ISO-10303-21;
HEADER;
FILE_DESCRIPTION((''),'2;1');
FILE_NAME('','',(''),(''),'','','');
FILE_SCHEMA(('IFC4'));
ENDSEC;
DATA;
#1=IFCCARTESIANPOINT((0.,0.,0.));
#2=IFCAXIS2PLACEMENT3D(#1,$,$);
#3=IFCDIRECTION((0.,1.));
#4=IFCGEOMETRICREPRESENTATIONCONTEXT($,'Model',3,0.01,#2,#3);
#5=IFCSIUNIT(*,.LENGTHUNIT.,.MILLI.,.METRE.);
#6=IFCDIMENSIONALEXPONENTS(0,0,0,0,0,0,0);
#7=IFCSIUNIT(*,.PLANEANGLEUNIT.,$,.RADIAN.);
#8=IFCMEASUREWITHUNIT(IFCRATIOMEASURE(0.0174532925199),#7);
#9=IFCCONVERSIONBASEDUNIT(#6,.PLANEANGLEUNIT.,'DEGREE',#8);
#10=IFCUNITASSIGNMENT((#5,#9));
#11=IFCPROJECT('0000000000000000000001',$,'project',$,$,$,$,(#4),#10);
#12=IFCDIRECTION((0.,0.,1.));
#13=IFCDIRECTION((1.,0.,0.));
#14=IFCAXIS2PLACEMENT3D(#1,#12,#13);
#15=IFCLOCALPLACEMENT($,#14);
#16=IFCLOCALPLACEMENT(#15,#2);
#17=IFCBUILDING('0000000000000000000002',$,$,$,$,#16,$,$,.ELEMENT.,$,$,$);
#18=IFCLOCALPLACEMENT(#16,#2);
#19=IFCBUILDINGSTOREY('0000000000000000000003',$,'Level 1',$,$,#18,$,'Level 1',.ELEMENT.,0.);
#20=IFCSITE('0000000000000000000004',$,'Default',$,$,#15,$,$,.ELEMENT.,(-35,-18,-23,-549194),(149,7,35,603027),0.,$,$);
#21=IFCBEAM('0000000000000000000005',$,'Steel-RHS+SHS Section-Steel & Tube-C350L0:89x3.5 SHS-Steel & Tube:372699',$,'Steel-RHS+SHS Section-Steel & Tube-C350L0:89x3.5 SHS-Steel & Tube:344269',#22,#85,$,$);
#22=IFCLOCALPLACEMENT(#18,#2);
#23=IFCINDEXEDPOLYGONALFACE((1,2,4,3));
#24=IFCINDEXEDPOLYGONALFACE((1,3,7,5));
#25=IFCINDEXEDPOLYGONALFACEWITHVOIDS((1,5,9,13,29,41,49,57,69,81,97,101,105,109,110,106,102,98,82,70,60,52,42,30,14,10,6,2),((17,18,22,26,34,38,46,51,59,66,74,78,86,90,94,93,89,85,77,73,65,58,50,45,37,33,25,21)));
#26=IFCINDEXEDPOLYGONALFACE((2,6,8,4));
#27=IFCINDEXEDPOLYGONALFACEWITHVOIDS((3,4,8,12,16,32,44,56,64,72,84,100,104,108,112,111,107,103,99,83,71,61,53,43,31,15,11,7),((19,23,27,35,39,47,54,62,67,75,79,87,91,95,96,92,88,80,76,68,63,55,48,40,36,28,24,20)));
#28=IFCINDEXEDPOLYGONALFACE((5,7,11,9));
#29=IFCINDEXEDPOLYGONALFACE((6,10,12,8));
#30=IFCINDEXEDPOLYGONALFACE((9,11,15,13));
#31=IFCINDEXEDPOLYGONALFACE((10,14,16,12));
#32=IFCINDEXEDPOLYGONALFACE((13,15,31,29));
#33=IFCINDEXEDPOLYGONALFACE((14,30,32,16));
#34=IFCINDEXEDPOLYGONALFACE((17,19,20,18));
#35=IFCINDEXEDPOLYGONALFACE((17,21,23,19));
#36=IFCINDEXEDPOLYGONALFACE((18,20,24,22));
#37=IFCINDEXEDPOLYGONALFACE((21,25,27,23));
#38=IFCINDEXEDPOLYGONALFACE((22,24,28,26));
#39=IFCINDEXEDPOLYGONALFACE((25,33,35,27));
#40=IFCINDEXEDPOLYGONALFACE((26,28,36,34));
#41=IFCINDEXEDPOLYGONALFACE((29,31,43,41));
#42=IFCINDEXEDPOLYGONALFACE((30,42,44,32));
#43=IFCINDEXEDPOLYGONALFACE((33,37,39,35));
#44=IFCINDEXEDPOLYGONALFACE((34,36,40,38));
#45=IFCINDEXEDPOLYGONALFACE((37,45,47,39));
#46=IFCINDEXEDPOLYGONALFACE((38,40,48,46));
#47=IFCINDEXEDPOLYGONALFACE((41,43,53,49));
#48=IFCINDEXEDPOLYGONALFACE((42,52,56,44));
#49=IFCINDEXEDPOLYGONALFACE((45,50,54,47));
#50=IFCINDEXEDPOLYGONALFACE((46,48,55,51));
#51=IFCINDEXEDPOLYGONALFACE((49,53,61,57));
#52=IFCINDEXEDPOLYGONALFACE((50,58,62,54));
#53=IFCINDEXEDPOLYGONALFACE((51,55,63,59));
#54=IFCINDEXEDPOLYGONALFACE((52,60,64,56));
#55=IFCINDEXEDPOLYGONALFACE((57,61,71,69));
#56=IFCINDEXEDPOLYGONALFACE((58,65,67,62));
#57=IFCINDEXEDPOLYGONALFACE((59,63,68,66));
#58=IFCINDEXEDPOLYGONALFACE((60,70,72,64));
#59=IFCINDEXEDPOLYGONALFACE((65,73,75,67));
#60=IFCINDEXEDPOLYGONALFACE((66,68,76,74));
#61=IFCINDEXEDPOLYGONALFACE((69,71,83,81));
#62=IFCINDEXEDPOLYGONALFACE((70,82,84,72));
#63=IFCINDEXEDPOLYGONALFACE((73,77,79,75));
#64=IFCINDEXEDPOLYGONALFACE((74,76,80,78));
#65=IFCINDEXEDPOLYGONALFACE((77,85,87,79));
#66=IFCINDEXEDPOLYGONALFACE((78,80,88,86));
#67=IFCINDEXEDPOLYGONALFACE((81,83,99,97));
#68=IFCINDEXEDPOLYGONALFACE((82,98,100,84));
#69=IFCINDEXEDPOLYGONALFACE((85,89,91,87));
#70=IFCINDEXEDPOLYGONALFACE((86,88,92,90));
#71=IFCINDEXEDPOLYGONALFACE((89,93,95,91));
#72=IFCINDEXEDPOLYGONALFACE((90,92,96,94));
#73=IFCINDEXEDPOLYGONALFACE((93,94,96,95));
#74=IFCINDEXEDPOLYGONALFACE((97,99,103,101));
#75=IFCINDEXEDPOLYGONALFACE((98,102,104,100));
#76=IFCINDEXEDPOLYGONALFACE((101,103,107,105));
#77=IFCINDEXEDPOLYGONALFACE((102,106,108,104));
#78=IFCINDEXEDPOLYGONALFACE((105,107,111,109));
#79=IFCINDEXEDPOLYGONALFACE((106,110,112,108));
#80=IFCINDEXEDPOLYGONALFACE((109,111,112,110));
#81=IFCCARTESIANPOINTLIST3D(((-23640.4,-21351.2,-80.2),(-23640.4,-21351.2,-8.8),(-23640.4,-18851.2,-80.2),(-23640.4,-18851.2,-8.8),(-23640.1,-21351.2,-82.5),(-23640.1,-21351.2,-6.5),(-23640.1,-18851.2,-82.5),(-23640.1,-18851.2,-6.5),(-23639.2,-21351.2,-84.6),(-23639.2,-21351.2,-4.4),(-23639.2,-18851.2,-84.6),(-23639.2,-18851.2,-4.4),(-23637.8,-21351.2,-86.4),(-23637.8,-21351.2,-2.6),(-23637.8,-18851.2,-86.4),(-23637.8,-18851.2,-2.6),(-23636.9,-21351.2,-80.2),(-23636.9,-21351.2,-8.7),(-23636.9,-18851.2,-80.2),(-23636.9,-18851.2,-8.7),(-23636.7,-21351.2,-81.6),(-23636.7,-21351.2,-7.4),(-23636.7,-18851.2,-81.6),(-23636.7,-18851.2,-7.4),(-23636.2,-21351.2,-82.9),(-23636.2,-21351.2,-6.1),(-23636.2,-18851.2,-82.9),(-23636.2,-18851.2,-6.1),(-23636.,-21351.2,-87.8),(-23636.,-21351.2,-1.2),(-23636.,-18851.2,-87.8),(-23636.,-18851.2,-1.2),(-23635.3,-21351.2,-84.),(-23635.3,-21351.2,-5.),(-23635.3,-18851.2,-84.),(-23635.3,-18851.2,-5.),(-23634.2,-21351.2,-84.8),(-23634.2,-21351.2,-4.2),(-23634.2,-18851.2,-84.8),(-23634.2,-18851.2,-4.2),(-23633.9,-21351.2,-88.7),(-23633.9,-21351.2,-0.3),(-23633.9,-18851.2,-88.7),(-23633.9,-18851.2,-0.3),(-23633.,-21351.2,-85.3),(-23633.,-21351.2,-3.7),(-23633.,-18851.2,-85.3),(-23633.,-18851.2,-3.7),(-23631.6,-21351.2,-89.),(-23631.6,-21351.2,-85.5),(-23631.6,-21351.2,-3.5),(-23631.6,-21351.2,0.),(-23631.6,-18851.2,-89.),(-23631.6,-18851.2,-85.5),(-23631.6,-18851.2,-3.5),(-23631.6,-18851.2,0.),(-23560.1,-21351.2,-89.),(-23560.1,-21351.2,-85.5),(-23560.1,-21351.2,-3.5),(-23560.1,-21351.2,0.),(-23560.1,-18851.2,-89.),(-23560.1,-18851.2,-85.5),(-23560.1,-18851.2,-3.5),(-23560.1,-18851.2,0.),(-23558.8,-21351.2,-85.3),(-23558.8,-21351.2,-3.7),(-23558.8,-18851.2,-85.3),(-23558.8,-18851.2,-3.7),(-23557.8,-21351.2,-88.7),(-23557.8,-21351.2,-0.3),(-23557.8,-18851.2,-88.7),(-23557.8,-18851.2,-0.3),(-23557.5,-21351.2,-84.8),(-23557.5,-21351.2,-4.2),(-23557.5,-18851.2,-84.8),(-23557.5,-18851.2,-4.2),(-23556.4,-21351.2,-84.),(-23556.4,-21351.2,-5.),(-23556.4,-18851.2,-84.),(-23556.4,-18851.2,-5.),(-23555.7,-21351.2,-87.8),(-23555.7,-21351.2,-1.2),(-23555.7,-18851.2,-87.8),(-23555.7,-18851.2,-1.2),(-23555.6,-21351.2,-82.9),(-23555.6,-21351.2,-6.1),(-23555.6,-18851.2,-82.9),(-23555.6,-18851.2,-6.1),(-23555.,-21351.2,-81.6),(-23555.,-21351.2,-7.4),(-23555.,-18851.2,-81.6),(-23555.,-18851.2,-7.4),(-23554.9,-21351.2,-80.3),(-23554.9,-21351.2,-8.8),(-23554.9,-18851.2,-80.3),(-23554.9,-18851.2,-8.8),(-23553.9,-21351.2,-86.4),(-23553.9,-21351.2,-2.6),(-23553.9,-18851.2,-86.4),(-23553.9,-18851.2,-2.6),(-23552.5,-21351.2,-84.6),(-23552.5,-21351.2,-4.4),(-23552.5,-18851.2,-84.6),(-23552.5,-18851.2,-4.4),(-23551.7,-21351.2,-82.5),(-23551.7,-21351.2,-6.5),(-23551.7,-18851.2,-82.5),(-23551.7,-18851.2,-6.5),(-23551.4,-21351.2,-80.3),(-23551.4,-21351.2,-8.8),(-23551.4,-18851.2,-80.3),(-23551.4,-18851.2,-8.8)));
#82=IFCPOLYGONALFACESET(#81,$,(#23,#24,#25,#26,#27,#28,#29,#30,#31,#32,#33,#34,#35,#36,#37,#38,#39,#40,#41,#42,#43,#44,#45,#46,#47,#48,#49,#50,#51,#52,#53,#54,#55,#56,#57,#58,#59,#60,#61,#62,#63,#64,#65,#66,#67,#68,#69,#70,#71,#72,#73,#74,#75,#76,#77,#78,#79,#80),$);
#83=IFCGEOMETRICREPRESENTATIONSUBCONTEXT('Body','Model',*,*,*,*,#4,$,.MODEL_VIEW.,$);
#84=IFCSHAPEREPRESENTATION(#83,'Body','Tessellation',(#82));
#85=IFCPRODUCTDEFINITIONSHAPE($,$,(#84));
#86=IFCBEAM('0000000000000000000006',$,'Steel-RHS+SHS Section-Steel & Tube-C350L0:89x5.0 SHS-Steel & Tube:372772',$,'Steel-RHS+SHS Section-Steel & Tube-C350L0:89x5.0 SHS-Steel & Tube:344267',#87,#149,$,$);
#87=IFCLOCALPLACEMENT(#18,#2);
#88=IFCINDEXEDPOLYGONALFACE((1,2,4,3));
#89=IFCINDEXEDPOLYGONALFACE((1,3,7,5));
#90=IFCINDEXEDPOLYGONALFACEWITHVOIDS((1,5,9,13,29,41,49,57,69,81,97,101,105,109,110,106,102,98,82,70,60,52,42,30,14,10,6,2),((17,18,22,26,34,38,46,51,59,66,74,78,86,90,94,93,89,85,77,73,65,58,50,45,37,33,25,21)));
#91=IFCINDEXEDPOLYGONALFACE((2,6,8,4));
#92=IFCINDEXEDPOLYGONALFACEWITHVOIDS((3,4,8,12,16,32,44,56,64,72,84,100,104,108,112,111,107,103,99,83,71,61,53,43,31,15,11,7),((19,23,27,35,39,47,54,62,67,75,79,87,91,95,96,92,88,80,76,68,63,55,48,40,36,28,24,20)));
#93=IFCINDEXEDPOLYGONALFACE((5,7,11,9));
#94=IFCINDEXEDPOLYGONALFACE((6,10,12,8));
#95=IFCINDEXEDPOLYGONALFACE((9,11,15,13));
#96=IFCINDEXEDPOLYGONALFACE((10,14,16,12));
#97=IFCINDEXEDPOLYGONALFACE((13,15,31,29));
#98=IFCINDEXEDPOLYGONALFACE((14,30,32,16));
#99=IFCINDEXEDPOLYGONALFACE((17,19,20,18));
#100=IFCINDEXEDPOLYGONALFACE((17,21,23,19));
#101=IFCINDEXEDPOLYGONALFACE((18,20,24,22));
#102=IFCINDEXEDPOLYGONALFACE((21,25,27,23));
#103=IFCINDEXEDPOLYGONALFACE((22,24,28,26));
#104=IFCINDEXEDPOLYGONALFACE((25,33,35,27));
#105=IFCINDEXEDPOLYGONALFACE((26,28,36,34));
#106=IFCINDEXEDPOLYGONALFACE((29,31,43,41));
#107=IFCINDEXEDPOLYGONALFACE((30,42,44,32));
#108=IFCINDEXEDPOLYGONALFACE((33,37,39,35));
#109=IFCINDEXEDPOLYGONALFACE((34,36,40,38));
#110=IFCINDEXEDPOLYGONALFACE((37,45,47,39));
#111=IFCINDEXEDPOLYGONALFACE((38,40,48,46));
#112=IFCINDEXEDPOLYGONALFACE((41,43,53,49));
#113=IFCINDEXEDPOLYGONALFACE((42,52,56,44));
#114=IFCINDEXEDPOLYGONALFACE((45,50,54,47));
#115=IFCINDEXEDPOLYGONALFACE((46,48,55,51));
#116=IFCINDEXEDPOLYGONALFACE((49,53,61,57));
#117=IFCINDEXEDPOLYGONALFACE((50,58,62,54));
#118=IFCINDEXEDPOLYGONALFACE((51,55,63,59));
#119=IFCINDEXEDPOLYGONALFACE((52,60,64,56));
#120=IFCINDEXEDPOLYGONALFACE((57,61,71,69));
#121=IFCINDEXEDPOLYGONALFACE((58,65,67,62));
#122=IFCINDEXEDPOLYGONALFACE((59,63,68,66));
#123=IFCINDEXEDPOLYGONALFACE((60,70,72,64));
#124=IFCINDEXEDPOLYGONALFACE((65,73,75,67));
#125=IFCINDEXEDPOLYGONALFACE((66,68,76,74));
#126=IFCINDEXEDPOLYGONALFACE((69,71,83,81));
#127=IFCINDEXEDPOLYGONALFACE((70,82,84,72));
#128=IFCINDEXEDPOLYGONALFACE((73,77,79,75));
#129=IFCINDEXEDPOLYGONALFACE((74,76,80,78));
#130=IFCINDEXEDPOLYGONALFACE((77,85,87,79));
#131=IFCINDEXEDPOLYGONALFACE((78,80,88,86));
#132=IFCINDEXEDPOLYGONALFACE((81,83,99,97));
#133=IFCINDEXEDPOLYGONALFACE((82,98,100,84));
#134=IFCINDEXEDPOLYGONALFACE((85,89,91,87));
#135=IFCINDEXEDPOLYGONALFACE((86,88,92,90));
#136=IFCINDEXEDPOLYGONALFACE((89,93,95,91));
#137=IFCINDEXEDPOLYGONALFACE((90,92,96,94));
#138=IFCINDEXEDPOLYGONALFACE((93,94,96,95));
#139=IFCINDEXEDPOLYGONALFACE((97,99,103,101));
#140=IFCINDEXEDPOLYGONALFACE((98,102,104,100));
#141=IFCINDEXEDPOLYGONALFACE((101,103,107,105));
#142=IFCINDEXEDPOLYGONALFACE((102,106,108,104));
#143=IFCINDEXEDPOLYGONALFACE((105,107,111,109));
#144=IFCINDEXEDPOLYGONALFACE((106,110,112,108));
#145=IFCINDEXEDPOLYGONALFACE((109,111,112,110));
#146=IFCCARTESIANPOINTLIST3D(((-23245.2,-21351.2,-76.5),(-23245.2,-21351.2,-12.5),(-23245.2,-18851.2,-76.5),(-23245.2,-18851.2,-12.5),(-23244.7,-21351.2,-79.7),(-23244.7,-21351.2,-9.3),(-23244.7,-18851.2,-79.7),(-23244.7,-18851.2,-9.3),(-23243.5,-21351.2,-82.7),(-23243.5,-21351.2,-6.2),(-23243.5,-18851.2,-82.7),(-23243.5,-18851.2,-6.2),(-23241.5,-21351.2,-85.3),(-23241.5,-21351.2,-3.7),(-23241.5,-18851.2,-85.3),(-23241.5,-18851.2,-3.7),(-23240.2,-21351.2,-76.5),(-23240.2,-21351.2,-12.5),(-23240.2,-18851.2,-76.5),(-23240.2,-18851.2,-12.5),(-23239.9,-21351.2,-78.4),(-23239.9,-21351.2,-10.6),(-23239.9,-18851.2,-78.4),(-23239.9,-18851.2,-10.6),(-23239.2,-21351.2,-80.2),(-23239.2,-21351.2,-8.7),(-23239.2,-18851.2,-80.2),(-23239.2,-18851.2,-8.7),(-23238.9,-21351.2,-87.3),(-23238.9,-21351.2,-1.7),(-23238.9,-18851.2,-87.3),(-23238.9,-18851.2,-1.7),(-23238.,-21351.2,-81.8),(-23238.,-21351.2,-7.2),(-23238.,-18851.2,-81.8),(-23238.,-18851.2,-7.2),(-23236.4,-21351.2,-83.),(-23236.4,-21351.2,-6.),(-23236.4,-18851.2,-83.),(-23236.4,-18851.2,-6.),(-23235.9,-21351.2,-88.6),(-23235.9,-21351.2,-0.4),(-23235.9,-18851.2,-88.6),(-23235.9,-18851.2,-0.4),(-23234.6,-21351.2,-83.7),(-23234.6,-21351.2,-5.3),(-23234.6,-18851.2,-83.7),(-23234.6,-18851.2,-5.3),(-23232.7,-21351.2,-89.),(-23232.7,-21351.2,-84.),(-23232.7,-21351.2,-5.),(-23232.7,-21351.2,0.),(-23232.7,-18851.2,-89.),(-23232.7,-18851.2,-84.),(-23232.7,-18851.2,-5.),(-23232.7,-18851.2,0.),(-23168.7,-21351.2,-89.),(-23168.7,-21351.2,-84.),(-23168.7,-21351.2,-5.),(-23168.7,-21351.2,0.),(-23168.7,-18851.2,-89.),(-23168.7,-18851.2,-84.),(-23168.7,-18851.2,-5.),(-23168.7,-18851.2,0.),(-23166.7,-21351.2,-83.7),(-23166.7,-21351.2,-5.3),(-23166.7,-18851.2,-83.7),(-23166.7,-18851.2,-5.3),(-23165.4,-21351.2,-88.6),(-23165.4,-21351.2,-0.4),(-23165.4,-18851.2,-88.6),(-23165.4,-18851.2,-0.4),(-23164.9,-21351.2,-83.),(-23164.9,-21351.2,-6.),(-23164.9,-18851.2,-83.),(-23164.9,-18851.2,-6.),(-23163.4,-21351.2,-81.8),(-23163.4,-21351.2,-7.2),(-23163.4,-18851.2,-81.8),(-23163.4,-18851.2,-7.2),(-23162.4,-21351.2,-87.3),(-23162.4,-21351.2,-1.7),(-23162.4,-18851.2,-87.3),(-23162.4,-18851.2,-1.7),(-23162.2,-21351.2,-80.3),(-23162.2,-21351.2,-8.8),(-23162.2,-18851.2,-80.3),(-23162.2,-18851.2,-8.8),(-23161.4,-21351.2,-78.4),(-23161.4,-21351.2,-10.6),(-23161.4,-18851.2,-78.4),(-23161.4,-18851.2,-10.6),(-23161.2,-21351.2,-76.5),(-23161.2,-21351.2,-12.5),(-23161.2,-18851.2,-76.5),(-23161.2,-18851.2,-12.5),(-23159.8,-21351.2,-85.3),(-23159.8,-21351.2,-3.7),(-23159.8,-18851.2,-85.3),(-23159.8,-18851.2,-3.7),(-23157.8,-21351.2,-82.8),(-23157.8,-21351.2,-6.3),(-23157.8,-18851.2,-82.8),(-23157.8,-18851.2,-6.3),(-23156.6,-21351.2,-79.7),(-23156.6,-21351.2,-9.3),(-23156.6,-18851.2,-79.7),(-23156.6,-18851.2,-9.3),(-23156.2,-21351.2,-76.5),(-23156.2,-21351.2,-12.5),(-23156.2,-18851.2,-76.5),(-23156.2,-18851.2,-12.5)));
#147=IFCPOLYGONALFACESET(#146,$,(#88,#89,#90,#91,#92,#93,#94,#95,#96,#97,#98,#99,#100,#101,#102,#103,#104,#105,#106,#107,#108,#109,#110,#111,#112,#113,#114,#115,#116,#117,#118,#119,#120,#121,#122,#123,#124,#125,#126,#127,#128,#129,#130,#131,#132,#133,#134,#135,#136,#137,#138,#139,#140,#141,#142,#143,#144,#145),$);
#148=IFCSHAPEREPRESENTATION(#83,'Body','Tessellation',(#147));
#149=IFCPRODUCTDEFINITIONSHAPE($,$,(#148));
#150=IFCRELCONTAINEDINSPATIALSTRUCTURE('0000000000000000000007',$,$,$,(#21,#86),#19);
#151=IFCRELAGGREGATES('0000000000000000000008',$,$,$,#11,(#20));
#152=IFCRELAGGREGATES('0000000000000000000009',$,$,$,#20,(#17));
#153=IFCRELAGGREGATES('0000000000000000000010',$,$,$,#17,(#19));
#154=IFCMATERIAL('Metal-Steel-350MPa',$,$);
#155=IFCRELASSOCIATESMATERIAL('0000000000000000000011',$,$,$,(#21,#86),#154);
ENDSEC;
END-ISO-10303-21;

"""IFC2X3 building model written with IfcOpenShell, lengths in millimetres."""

from ifc_helpers import new_model, entity, si_unit, converted_unit, direction, frame, frame_2d, origin, origin_with_axes, place, context, subcontext, project, spatial, polyline, circle_curve, parameter, trimmed, segment, composite_curve, outline, extrude, material, element, save


model = new_model("IFC2X3")

# Units and contexts
model_context = context("Model", 3, precision=0.01, world=origin(), true_north=direction((0.0, 1.0)))
body_context = subcontext(model_context, "Body", "Model", "MODEL_VIEW")
ifc_project = project(units=[si_unit("LENGTHUNIT", "METRE", prefix="MILLI"), converted_unit("PLANEANGLEUNIT", "DEGREE", entity("IfcRatioMeasure", 0.0174532925199), si_unit("PLANEANGLEUNIT", "RADIAN"), dimensions=[0, 0, 0, 0, 0, 0, 0])], contexts=[model_context])

# Site, building, storey
site_placement = place(None, origin_with_axes())
site = spatial("IfcSite", under=ifc_project, at=site_placement, Name="Default", CompositionType="ELEMENT", RefLatitude=(-35, -18, -23, -549194), RefLongitude=(149, 7, 35, 603027), RefElevation=0.0)
building_placement = place(site_placement, origin())
building = spatial("IfcBuilding", under=site, at=building_placement, CompositionType="ELEMENT")
storey_placement = place(building_placement, origin())
storey = spatial("IfcBuildingStorey", under=building, at=storey_placement, Name="Level 1", LongName="Level 1", CompositionType="ELEMENT", Elevation=0.0)

# Beams
ifc_material = material(Name="Metal-Steel-350MPa")
beam_1_placement = place(storey_placement, frame((-23595.9, -18851.2, 0.0), z_axis=(0.0, 0.0, 1.0), x_axis=(0.0, -1.0, 0.0)))
element("IfcBeam", 1, at=beam_1_placement, inside=storey, material=ifc_material, Name="Steel-RHS+SHS Section-Steel & Tube-C350L0:89x3.5 SHS-Steel & Tube:372699", ObjectType="Steel-RHS+SHS Section-Steel & Tube-C350L0:89x3.5 SHS-Steel & Tube:344269", context=body_context, shape_type="SweptSolid", body=[
    extrude(outline(composite_curve([segment(trimmed(circle_curve(frame_2d((-35.8, -35.8), x_axis=(1.0, 0.0)), 8.8), [parameter(180.0)], [parameter(270.0)], True, "PARAMETER"), True, "CONTINUOUS"), segment(polyline([(-35.8, -44.5), (35.8, -44.5)]), True, "CONTINUOUS"), segment(trimmed(circle_curve(frame_2d((35.8, -35.8), x_axis=(1.0, 0.0)), 8.8), [parameter(270.0)], [parameter(0.0)], True, "PARAMETER"), True, "CONTINUOUS"), segment(polyline([(44.5, -35.8), (44.5, 35.8)]), True, "CONTINUOUS"), segment(trimmed(circle_curve(frame_2d((35.8, 35.8), x_axis=(1.0, 0.0)), 8.8), [parameter(0.0)], [parameter(90.0)], True, "PARAMETER"), True, "CONTINUOUS"), segment(polyline([(35.8, 44.5), (-35.8, 44.5)]), True, "CONTINUOUS"), segment(trimmed(circle_curve(frame_2d((-35.8, 35.8), x_axis=(1.0, 0.0)), 8.8), [parameter(90.0)], [parameter(180.0)], True, "PARAMETER"), True, "CONTINUOUS"), segment(polyline([(-44.5, 35.8), (-44.5, -35.8)]), True, "CONTINUOUS")], self_intersect=False), holes=[composite_curve([segment(polyline([(35.8, -41.0), (-35.8, -41.0)]), True, "CONTINUOUS"), segment(trimmed(circle_curve(frame_2d((-35.8, -35.8), x_axis=(1.0, 0.0)), 5.2), [parameter(180.0)], [parameter(270.0)], True, "PARAMETER"), False, "CONTINUOUS"), segment(polyline([(-41.0, -35.8), (-41.0, 35.8)]), True, "CONTINUOUS"), segment(trimmed(circle_curve(frame_2d((-35.8, 35.8), x_axis=(1.0, 0.0)), 5.2), [parameter(90.0)], [parameter(180.0)], True, "PARAMETER"), False, "CONTINUOUS"), segment(polyline([(-35.8, 41.0), (35.8, 41.0)]), True, "CONTINUOUS"), segment(trimmed(circle_curve(frame_2d((35.8, 35.8), x_axis=(1.0, 0.0)), 5.2), [parameter(360.0)], [parameter(90.0)], True, "PARAMETER"), False, "CONTINUOUS"), segment(polyline([(41.0, 35.8), (41.0, -35.8)]), True, "CONTINUOUS"), segment(trimmed(circle_curve(frame_2d((35.8, -35.8), x_axis=(1.0, 0.0)), 5.2), [parameter(270.0)], [parameter(360.0)], True, "PARAMETER"), False, "CONTINUOUS")], self_intersect=False)]), frame((0.0, 0.0, -44.5), z_axis=(1.0, 0.0, 0.0), x_axis=(0.0, -1.0, 0.0)), (0.0, 0.0, 1.0), 2500.0),
])
beam_2_placement = place(storey_placement, frame((-23200.7, -18851.2, 0.0), z_axis=(0.0, 0.0, 1.0), x_axis=(0.0, -1.0, 0.0)))
element("IfcBeam", 2, at=beam_2_placement, inside=storey, material=ifc_material, Name="Steel-RHS+SHS Section-Steel & Tube-C350L0:89x5.0 SHS-Steel & Tube:372772", ObjectType="Steel-RHS+SHS Section-Steel & Tube-C350L0:89x5.0 SHS-Steel & Tube:344267", context=body_context, shape_type="SweptSolid", body=[
    extrude(outline(composite_curve([segment(trimmed(circle_curve(frame_2d((-32.0, -32.0), x_axis=(1.0, 0.0)), 12.5), [parameter(180.0)], [parameter(270.0)], True, "PARAMETER"), True, "CONTINUOUS"), segment(polyline([(-32.0, -44.5), (32.0, -44.5)]), True, "CONTINUOUS"), segment(trimmed(circle_curve(frame_2d((32.0, -32.0), x_axis=(1.0, 0.0)), 12.5), [parameter(270.0)], [parameter(0.0)], True, "PARAMETER"), True, "CONTINUOUS"), segment(polyline([(44.5, -32.0), (44.5, 32.0)]), True, "CONTINUOUS"), segment(trimmed(circle_curve(frame_2d((32.0, 32.0), x_axis=(1.0, 0.0)), 12.5), [parameter(0.0)], [parameter(90.0)], True, "PARAMETER"), True, "CONTINUOUS"), segment(polyline([(32.0, 44.5), (-32.0, 44.5)]), True, "CONTINUOUS"), segment(trimmed(circle_curve(frame_2d((-32.0, 32.0), x_axis=(1.0, 0.0)), 12.5), [parameter(90.0)], [parameter(180.0)], True, "PARAMETER"), True, "CONTINUOUS"), segment(polyline([(-44.5, 32.0), (-44.5, -32.0)]), True, "CONTINUOUS")], self_intersect=False), holes=[composite_curve([segment(polyline([(32.0, -39.5), (-32.0, -39.5)]), True, "CONTINUOUS"), segment(trimmed(circle_curve(frame_2d((-32.0, -32.0), x_axis=(1.0, 0.0)), 7.5), [parameter(180.0)], [parameter(270.0)], True, "PARAMETER"), False, "CONTINUOUS"), segment(polyline([(-39.5, -32.0), (-39.5, 32.0)]), True, "CONTINUOUS"), segment(trimmed(circle_curve(frame_2d((-32.0, 32.0), x_axis=(1.0, 0.0)), 7.5), [parameter(90.0)], [parameter(180.0)], True, "PARAMETER"), False, "CONTINUOUS"), segment(polyline([(-32.0, 39.5), (32.0, 39.5)]), True, "CONTINUOUS"), segment(trimmed(circle_curve(frame_2d((32.0, 32.0), x_axis=(1.0, 0.0)), 7.5), [parameter(360.0)], [parameter(90.0)], True, "PARAMETER"), False, "CONTINUOUS"), segment(polyline([(39.5, 32.0), (39.5, -32.0)]), True, "CONTINUOUS"), segment(trimmed(circle_curve(frame_2d((32.0, -32.0), x_axis=(1.0, 0.0)), 7.5), [parameter(270.0)], [parameter(0.0)], True, "PARAMETER"), False, "CONTINUOUS")], self_intersect=False)]), frame((0.0, 0.0, -44.5), z_axis=(1.0, 0.0, 0.0), x_axis=(0.0, -1.0, 0.0)), (0.0, 0.0, 1.0), 2500.0),
])

save(model, "model.ifc")
